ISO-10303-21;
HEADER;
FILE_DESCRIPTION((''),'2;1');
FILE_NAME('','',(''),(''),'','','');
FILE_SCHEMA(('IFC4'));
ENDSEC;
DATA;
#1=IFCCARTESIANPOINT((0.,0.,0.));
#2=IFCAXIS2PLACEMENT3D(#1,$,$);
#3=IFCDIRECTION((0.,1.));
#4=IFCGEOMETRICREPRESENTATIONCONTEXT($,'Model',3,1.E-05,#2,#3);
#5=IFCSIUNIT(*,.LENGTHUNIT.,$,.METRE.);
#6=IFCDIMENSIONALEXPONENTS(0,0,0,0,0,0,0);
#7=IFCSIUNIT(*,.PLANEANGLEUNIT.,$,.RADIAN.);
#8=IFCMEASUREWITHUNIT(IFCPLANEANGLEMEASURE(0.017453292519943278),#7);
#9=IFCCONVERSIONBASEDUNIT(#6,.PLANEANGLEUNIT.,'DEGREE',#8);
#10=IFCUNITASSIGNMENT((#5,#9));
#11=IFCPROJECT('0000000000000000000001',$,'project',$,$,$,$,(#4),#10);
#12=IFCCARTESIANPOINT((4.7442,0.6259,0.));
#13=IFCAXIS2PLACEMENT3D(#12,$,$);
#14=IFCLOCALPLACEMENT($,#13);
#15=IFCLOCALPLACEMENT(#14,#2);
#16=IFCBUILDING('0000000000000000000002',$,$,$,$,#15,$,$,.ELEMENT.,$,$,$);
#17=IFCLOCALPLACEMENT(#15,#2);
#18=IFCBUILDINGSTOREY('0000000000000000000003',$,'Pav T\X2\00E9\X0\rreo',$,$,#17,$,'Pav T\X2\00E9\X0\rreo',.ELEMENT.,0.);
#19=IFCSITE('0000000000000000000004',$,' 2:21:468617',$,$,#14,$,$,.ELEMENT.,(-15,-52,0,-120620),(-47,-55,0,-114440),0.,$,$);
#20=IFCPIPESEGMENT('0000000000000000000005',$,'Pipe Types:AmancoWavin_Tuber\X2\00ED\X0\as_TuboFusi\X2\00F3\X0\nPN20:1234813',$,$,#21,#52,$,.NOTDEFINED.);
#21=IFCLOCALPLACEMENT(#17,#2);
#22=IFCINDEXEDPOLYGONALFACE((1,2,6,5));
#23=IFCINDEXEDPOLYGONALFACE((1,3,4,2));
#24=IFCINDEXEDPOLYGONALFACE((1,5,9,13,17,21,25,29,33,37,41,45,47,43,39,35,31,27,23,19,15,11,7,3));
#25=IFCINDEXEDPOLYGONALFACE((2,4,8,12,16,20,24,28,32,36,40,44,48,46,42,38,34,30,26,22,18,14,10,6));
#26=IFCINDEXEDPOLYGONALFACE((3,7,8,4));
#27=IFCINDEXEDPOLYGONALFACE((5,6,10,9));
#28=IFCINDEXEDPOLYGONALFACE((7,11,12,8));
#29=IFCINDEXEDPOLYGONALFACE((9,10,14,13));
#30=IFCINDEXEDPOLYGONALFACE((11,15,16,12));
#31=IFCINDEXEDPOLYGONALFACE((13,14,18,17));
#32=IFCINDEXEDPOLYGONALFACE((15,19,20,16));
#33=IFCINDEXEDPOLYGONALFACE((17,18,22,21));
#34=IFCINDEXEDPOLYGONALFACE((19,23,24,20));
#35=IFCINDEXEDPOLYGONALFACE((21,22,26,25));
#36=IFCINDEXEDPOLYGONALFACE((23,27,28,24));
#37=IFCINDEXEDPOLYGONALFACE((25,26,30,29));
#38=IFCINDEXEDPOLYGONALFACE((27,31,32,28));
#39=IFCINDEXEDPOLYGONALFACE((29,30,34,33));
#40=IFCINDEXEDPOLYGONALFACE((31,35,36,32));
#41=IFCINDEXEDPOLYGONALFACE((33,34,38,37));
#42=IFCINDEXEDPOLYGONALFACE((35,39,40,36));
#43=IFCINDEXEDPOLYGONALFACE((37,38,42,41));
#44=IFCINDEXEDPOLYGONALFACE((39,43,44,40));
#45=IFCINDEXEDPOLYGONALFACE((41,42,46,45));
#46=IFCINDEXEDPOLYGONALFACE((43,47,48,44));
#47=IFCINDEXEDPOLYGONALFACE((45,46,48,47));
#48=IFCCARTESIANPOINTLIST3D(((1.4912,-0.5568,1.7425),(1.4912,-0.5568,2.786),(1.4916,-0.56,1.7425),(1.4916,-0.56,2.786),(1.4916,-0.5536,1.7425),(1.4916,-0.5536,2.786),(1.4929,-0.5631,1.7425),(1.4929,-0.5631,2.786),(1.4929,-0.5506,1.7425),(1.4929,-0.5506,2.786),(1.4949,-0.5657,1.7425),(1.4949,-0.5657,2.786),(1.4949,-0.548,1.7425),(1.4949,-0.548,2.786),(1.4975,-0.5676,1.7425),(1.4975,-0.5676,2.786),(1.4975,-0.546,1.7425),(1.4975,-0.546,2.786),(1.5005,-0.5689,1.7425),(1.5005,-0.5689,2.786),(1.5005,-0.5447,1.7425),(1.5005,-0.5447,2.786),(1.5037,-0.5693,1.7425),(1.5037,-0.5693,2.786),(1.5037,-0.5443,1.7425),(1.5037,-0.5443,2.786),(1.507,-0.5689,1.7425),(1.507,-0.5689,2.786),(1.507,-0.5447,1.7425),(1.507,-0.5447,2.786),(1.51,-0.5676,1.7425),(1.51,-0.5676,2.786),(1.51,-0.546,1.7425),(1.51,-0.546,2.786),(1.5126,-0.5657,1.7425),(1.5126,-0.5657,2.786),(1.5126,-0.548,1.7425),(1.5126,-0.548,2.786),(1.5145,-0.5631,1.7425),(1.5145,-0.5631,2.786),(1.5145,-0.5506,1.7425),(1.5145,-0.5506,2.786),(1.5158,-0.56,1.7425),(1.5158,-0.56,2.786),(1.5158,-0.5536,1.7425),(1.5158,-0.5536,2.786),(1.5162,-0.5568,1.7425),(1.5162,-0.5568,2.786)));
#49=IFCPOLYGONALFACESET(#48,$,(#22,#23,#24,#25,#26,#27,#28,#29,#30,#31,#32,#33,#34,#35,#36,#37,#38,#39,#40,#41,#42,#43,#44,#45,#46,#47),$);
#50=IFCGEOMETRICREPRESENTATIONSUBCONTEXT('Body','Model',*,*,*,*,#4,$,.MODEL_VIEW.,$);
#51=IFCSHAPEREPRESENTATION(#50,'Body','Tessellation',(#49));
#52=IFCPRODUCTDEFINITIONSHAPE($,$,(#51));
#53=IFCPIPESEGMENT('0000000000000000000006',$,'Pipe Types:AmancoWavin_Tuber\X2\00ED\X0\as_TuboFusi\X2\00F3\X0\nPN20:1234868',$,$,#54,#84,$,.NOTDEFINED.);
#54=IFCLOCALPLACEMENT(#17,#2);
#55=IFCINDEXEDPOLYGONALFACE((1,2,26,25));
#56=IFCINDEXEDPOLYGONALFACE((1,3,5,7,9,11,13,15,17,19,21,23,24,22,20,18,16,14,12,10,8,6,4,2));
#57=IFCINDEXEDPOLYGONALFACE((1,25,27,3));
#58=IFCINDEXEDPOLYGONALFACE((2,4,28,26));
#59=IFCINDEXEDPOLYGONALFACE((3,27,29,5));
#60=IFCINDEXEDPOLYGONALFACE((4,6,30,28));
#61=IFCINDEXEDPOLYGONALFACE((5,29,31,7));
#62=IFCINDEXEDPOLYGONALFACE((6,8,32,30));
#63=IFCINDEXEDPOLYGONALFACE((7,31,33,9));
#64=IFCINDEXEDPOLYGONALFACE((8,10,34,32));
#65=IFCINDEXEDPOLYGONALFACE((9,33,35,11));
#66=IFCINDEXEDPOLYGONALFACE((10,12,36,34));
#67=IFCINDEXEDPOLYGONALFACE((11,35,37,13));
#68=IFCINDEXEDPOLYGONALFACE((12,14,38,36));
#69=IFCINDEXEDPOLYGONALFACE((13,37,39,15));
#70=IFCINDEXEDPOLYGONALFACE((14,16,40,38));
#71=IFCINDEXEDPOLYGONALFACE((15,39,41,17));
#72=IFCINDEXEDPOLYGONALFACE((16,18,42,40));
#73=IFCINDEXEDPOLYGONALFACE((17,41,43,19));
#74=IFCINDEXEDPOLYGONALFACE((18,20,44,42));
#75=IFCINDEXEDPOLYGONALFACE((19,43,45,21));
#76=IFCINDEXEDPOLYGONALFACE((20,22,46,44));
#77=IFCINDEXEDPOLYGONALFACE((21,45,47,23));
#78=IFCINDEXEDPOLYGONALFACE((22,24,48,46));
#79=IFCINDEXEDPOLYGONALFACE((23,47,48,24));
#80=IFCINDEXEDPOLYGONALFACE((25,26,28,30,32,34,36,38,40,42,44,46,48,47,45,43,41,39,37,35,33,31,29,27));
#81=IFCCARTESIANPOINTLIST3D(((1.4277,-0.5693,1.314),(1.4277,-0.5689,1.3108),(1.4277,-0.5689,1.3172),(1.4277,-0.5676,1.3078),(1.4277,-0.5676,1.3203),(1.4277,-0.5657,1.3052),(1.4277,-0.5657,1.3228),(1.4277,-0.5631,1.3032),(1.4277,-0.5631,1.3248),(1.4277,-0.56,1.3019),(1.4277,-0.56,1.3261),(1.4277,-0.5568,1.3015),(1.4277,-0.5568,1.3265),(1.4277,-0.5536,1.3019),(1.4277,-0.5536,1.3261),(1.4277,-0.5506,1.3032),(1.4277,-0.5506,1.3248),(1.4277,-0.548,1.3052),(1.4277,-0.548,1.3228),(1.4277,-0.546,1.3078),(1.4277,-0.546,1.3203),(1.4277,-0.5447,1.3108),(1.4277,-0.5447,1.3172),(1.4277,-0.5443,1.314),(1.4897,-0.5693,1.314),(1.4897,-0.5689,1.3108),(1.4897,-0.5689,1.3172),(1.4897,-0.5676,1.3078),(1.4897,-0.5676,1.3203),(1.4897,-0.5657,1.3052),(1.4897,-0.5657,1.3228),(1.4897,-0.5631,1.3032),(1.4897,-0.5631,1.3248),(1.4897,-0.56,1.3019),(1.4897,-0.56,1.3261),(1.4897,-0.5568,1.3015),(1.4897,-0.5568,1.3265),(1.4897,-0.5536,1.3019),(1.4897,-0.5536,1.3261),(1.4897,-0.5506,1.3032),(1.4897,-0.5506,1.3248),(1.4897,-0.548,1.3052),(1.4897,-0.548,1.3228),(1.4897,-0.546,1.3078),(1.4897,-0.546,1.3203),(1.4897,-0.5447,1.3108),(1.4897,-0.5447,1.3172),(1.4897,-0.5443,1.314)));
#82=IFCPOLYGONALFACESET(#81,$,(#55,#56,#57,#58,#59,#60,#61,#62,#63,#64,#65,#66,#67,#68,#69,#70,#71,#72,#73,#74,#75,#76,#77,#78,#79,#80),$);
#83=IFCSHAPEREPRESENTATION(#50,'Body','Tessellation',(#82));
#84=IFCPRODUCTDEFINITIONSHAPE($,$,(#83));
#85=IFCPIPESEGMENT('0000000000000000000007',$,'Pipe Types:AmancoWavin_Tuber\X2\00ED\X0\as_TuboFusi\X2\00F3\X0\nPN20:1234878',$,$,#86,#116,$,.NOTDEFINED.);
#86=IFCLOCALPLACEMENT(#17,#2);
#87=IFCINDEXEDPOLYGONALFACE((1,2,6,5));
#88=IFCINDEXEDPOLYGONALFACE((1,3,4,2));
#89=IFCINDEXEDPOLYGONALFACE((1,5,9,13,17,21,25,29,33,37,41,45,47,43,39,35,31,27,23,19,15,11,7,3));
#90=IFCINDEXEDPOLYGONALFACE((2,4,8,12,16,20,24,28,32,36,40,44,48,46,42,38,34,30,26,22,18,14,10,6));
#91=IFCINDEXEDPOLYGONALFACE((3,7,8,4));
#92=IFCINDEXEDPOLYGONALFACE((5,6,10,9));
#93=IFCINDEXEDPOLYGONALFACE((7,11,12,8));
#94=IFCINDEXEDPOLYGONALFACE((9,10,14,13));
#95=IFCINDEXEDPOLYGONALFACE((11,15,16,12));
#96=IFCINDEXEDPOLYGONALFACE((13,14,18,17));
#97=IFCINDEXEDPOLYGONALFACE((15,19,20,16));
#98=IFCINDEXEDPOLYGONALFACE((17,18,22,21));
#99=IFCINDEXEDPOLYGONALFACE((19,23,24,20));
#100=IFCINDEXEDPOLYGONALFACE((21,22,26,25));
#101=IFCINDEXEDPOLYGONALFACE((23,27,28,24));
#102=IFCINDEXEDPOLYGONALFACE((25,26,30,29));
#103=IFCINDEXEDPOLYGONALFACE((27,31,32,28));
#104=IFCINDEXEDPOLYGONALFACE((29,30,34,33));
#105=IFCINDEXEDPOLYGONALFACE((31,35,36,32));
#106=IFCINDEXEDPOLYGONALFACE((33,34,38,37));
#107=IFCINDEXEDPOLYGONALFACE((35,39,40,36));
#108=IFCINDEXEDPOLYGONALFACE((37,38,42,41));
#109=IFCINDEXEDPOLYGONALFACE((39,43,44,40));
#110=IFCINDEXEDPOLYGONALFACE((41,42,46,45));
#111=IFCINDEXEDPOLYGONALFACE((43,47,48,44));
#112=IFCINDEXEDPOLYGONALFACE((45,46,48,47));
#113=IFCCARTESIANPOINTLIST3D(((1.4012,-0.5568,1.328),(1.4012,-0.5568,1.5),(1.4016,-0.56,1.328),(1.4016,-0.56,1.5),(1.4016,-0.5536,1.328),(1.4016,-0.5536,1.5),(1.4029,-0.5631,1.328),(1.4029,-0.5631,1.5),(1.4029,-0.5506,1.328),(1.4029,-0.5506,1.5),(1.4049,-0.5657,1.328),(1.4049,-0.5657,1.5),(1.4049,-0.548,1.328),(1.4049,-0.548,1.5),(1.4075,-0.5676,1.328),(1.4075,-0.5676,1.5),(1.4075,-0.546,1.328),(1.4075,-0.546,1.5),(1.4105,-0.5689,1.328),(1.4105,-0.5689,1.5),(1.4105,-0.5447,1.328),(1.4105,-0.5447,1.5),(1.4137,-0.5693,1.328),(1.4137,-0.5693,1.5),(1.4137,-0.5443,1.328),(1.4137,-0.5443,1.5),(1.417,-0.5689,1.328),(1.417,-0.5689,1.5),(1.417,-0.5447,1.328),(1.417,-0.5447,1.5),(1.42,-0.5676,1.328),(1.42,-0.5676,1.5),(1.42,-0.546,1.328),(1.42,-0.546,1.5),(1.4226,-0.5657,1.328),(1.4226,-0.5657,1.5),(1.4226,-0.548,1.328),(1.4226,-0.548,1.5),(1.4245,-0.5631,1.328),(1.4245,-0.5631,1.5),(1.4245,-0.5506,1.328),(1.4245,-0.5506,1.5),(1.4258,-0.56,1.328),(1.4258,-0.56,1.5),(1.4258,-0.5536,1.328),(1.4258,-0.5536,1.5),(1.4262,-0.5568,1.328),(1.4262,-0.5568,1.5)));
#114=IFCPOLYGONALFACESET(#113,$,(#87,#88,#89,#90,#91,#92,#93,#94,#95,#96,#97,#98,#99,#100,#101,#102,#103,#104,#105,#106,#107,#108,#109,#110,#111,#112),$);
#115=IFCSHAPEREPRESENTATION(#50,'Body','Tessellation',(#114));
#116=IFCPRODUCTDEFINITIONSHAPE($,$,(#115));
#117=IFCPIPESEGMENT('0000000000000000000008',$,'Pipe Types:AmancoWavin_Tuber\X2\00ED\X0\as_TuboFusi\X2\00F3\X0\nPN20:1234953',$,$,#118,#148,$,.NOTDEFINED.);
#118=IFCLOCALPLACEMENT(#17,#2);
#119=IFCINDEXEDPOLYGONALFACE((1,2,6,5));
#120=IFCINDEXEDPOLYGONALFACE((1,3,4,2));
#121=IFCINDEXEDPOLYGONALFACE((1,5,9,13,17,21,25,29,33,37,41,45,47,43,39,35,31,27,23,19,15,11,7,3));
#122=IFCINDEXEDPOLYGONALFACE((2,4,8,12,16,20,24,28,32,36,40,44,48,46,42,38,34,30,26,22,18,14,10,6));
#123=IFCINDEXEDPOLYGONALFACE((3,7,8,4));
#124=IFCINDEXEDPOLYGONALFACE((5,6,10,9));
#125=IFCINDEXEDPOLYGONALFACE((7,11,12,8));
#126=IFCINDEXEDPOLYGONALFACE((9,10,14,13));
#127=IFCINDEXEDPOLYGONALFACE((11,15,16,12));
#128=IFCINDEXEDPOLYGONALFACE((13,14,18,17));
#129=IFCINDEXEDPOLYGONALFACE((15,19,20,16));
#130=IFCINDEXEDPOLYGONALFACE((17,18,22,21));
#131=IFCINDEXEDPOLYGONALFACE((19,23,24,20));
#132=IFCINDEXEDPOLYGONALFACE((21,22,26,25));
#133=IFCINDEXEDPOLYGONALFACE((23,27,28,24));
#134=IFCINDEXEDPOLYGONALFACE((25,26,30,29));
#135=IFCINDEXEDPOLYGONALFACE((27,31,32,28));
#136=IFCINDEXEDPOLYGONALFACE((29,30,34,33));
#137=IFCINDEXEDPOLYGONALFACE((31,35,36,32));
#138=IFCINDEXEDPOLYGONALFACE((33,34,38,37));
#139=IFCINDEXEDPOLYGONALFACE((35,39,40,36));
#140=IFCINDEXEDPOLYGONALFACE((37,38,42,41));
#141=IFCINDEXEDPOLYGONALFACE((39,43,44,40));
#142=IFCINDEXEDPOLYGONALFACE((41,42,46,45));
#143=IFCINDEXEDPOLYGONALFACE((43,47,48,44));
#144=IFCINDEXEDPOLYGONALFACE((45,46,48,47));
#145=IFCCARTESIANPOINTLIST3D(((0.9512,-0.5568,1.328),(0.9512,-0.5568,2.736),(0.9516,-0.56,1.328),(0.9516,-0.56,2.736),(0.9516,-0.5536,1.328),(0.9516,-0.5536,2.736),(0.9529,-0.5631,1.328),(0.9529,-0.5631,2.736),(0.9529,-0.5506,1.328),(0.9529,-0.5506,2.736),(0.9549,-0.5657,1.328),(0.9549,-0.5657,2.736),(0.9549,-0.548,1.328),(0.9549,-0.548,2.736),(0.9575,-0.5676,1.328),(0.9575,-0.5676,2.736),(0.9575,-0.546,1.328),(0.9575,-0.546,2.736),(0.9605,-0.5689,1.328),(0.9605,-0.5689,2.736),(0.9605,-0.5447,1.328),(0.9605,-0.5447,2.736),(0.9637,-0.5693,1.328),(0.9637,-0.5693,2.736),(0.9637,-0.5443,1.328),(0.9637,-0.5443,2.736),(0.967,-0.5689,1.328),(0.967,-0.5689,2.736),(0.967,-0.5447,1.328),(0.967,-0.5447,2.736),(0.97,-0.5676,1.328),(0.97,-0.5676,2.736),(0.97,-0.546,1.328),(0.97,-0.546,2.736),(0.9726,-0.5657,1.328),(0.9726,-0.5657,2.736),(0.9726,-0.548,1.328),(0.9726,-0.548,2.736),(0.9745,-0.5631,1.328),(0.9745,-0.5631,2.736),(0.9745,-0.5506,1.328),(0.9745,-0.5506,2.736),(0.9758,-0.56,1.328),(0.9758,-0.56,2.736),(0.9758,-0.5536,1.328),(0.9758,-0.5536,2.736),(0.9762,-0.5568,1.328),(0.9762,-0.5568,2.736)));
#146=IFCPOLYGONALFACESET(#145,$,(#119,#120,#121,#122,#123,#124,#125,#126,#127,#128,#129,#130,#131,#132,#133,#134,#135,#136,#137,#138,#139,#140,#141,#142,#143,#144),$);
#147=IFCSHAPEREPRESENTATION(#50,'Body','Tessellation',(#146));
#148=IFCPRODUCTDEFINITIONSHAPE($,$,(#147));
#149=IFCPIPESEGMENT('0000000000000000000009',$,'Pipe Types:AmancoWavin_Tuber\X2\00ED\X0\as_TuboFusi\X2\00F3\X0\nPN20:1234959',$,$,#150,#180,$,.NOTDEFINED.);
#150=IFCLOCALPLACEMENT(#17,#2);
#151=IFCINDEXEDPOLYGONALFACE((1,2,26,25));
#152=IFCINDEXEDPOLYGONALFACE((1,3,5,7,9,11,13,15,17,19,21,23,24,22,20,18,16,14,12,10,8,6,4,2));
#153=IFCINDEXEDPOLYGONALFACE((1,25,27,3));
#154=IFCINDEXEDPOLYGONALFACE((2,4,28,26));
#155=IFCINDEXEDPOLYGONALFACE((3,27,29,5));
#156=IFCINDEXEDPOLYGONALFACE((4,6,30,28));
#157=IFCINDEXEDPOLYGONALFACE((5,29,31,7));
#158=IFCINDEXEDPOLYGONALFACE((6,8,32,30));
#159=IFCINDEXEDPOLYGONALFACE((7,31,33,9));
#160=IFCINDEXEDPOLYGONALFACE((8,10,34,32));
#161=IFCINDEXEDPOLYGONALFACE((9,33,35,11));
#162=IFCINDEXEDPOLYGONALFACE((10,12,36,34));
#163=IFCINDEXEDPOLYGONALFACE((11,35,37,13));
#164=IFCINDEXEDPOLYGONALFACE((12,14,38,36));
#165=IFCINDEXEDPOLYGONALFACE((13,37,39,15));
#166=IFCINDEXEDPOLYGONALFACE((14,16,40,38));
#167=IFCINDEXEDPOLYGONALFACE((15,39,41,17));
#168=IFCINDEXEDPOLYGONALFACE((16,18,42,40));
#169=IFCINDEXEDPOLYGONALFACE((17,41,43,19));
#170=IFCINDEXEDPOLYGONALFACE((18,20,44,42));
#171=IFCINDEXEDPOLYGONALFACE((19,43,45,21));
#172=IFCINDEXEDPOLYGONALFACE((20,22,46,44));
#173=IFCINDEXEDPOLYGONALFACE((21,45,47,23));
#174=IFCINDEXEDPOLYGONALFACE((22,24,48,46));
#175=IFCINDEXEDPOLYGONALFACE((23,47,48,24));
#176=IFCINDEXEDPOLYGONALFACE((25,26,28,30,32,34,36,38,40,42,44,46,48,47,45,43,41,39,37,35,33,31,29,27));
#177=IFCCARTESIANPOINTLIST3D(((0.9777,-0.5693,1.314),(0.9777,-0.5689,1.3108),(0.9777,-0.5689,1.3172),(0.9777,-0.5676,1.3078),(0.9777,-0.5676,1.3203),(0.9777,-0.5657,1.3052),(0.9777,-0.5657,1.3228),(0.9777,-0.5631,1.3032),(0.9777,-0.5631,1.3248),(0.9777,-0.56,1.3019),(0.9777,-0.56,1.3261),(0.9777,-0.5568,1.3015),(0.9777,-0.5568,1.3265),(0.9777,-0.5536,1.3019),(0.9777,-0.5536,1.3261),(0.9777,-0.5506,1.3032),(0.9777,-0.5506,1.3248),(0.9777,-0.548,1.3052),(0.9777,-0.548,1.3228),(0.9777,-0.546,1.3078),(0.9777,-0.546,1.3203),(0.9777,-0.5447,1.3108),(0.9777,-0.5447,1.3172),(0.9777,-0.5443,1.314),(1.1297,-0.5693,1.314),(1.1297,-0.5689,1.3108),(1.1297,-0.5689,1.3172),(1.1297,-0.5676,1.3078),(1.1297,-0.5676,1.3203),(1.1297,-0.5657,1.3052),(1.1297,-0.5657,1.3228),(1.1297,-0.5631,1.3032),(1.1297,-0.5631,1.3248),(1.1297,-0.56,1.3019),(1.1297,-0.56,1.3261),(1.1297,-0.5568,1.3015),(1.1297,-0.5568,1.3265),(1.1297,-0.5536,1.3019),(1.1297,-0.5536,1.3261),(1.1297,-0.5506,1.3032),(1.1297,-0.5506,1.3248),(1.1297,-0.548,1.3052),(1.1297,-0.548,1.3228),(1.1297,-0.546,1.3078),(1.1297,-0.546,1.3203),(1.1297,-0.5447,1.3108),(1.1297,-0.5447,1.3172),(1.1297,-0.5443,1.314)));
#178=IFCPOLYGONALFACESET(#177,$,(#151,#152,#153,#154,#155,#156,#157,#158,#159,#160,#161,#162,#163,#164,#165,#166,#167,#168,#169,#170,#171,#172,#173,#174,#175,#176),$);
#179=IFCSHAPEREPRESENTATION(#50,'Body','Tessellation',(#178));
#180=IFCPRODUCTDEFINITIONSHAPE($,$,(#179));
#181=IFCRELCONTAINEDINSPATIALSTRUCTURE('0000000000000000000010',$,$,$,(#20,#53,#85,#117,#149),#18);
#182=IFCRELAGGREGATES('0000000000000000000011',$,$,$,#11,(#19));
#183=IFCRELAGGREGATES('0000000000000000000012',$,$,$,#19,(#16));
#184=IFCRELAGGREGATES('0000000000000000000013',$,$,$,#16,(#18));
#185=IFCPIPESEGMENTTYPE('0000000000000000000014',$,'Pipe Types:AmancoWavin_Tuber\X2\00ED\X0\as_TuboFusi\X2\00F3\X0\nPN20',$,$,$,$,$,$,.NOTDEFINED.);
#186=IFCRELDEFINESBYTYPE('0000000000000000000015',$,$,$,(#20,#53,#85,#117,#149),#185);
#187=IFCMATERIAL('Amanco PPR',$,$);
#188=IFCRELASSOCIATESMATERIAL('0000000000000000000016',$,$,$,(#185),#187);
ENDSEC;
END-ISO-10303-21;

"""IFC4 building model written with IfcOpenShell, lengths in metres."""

from ifc_helpers import new_model, entity, si_unit, converted_unit, direction, frame, origin, place, context, subcontext, project, spatial, arc, indexed_curve, outline, extrude, material, type_object, element, save


model = new_model("IFC4")

# Units and contexts
model_context = context("Model", 3, precision=1e-05, world=origin(), true_north=direction((0.0, 1.0)))
body_context = subcontext(model_context, "Body", "Model", "MODEL_VIEW")
ifc_project = project(units=[si_unit("LENGTHUNIT", "METRE"), converted_unit("PLANEANGLEUNIT", "DEGREE", entity("IfcPlaneAngleMeasure", 0.017453292519943278), si_unit("PLANEANGLEUNIT", "RADIAN"), dimensions=[0, 0, 0, 0, 0, 0, 0])], contexts=[model_context])

# Site, building, storey
site_placement = place(None, frame((4.7442, 0.6259, 0.0)))
site = spatial("IfcSite", under=ifc_project, at=site_placement, Name=" 2:21:468617", CompositionType="ELEMENT", RefLatitude=(-15, -52, 0, -120620), RefLongitude=(-47, -55, 0, -114440), RefElevation=0.0)
building_placement = place(site_placement, origin())
building = spatial("IfcBuilding", under=site, at=building_placement, CompositionType="ELEMENT")
storey_placement = place(building_placement, origin())
storey = spatial("IfcBuildingStorey", under=building, at=storey_placement, Name="Pav Térreo", LongName="Pav Térreo", CompositionType="ELEMENT", Elevation=0.0)

# Pipe segments
ifc_material_1 = material(Name="Amanco PPR")
pipe_segment_type_1 = type_object("IfcPipeSegmentType", Name="Pipe Types:AmancoWavin_Tuberías_TuboFusiónPN20", PredefinedType="NOTDEFINED", material=ifc_material_1)
pipe_segment_1_placement = place(storey_placement, origin())
element("IfcPipeSegment", 1, at=pipe_segment_1_placement, inside=storey, type_object=pipe_segment_type_1, Name="Pipe Types:AmancoWavin_Tuberías_TuboFusiónPN20:1234813", PredefinedType="NOTDEFINED", context=body_context, shape_type="SweptSolid", body=[
    extrude(outline(indexed_curve([(0.0125, 0.0), (0.0088, 0.0088), (0.0, 0.0125), (-0.0088, 0.0088), (-0.0125, 0.0), (-0.0088, -0.0088), (0.0, -0.0125), (0.0088, -0.0088)], segments=[arc(1, 2, 3), arc(3, 4, 5), arc(5, 6, 7), arc(7, 8, 1)], self_intersect=False)), frame((1.5037, -0.5568, 1.7425)), (0.0, 0.0, 1.0), 1.0435),
])
pipe_segment_2_placement = place(storey_placement, origin())
element("IfcPipeSegment", 2, at=pipe_segment_2_placement, inside=storey, type_object=pipe_segment_type_1, Name="Pipe Types:AmancoWavin_Tuberías_TuboFusiónPN20:1234868", PredefinedType="NOTDEFINED", context=body_context, shape_type="SweptSolid", body=[
    extrude(outline(indexed_curve([(0.0125, 0.0), (0.0088, 0.0088), (0.0, 0.0125), (-0.0088, 0.0088), (-0.0125, 0.0), (-0.0088, -0.0088), (0.0, -0.0125), (0.0088, -0.0088)], segments=[arc(1, 2, 3), arc(3, 4, 5), arc(5, 6, 7), arc(7, 8, 1)], self_intersect=False)), frame((1.4277, -0.5568, 1.314), z_axis=(1.0, 0.0, 0.0), x_axis=(0.0, 1.0, 0.0)), (0.0, 0.0, 1.0), 0.062),
])
pipe_segment_3_placement = place(storey_placement, origin())
element("IfcPipeSegment", 3, at=pipe_segment_3_placement, inside=storey, type_object=pipe_segment_type_1, Name="Pipe Types:AmancoWavin_Tuberías_TuboFusiónPN20:1234878", PredefinedType="NOTDEFINED", context=body_context, shape_type="SweptSolid", body=[
    extrude(outline(indexed_curve([(0.0125, 0.0), (0.0088, 0.0088), (0.0, 0.0125), (-0.0088, 0.0088), (-0.0125, 0.0), (-0.0088, -0.0088), (0.0, -0.0125), (0.0088, -0.0088)], segments=[arc(1, 2, 3), arc(3, 4, 5), arc(5, 6, 7), arc(7, 8, 1)], self_intersect=False)), frame((1.4137, -0.5568, 1.328), z_axis=(0.0, 0.0, 1.0), x_axis=(-1.0, 0.0, 0.0)), (0.0, 0.0, 1.0), 0.172),
])
pipe_segment_4_placement = place(storey_placement, origin())
element("IfcPipeSegment", 4, at=pipe_segment_4_placement, inside=storey, type_object=pipe_segment_type_1, Name="Pipe Types:AmancoWavin_Tuberías_TuboFusiónPN20:1234953", PredefinedType="NOTDEFINED", context=body_context, shape_type="SweptSolid", body=[
    extrude(outline(indexed_curve([(0.0125, 0.0), (0.0088, 0.0088), (0.0, 0.0125), (-0.0088, 0.0088), (-0.0125, 0.0), (-0.0088, -0.0088), (0.0, -0.0125), (0.0088, -0.0088)], segments=[arc(1, 2, 3), arc(3, 4, 5), arc(5, 6, 7), arc(7, 8, 1)], self_intersect=False)), frame((0.9637, -0.5568, 1.328)), (0.0, 0.0, 1.0), 1.408),
])
pipe_segment_5_placement = place(storey_placement, origin())
element("IfcPipeSegment", 5, at=pipe_segment_5_placement, inside=storey, type_object=pipe_segment_type_1, Name="Pipe Types:AmancoWavin_Tuberías_TuboFusiónPN20:1234959", PredefinedType="NOTDEFINED", context=body_context, shape_type="SweptSolid", body=[
    extrude(outline(indexed_curve([(0.0125, 0.0), (0.0088, 0.0088), (0.0, 0.0125), (-0.0088, 0.0088), (-0.0125, 0.0), (-0.0088, -0.0088), (0.0, -0.0125), (0.0088, -0.0088)], segments=[arc(1, 2, 3), arc(3, 4, 5), arc(5, 6, 7), arc(7, 8, 1)], self_intersect=False)), frame((0.9777, -0.5568, 1.314), z_axis=(1.0, 0.0, 0.0), x_axis=(0.0, -1.0, 0.0)), (0.0, 0.0, 1.0), 0.152),
])

save(model, "model.ifc")
